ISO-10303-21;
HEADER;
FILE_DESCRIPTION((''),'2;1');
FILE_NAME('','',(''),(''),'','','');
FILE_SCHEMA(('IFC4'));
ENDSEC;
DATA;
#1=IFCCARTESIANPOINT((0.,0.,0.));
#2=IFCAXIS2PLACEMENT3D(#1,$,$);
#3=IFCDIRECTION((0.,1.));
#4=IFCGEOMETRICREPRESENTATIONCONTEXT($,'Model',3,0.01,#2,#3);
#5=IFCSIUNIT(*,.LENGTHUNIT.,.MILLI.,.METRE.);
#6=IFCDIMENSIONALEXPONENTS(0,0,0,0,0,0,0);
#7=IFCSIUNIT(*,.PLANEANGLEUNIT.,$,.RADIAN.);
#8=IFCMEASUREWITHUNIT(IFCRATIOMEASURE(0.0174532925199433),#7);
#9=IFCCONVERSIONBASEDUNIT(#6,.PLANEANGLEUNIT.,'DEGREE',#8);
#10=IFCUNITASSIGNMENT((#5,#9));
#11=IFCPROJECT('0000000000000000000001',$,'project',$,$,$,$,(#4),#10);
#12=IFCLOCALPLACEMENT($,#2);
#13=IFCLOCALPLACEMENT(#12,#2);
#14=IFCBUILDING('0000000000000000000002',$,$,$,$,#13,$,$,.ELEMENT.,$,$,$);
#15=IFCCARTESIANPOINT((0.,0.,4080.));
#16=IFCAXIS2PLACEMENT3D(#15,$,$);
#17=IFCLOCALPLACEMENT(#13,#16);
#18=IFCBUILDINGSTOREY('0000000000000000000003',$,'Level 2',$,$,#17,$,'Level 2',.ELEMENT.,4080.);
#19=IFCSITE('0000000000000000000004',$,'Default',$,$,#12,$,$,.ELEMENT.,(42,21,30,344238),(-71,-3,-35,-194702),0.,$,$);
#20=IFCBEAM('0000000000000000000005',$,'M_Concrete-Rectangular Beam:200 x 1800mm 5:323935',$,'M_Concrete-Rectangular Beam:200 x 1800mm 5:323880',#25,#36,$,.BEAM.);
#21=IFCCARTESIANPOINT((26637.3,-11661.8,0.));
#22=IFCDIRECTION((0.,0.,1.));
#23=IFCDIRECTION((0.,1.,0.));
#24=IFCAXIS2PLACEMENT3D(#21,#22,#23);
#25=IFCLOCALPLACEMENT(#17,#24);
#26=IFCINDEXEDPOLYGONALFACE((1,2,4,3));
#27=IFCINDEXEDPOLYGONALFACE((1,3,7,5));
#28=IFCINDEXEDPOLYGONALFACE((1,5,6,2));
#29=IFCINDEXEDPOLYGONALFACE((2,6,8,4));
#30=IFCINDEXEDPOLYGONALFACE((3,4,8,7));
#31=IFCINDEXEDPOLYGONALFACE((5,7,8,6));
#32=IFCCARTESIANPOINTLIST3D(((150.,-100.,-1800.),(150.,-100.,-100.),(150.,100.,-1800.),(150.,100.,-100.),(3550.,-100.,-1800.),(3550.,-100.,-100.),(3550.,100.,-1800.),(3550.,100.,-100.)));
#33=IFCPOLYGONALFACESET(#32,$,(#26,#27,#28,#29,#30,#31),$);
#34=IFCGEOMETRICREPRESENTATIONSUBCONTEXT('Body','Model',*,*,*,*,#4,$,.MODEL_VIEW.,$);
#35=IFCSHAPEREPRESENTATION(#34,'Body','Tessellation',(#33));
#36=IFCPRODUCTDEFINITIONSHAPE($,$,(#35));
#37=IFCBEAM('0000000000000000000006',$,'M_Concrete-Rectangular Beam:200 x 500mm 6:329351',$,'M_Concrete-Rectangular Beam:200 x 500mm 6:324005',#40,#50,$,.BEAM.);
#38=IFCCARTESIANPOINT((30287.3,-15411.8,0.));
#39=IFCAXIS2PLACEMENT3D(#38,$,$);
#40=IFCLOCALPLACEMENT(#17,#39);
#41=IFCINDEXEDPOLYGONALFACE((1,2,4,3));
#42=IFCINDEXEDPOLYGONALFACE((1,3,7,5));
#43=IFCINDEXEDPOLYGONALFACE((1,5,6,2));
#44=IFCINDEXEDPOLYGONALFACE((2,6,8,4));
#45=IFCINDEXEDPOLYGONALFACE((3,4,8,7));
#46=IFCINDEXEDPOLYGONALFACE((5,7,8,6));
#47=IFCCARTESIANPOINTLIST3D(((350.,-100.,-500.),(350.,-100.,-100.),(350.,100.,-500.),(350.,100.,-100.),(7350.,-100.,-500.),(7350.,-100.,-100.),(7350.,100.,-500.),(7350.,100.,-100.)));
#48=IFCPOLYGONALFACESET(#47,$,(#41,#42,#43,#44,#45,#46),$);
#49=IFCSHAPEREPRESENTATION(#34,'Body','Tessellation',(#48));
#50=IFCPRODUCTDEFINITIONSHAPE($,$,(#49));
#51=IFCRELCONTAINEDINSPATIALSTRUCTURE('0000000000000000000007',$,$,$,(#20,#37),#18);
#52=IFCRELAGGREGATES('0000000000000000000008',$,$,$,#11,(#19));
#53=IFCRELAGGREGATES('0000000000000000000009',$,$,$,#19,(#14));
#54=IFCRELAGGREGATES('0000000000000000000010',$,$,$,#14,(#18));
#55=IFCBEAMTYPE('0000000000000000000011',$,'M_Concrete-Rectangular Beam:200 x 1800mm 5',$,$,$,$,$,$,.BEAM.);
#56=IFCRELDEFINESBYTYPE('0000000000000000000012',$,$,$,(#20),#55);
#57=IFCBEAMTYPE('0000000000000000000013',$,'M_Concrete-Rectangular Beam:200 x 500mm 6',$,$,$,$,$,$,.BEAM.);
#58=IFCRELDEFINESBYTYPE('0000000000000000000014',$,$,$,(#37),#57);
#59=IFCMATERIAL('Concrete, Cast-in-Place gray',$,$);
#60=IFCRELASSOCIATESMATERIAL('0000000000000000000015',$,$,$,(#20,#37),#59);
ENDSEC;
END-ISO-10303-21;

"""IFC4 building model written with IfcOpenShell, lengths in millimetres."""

from ifc_helpers import new_model, entity, si_unit, converted_unit, direction, frame, frame_2d, origin, place, context, subcontext, project, spatial, rectangle, extrude, material, type_object, element, save


model = new_model("IFC4")

# Units and contexts
model_context = context("Model", 3, precision=0.01, world=origin(), true_north=direction((0.0, 1.0)))
body_context = subcontext(model_context, "Body", "Model", "MODEL_VIEW")
ifc_project = project(units=[si_unit("LENGTHUNIT", "METRE", prefix="MILLI"), converted_unit("PLANEANGLEUNIT", "DEGREE", entity("IfcRatioMeasure", 0.0174532925199433), si_unit("PLANEANGLEUNIT", "RADIAN"), dimensions=[0, 0, 0, 0, 0, 0, 0])], contexts=[model_context])

# Site, building, storey
site_placement = place(None, origin())
site = spatial("IfcSite", under=ifc_project, at=site_placement, Name="Default", CompositionType="ELEMENT", RefLatitude=(42, 21, 30, 344238), RefLongitude=(-71, -3, -35, -194702), RefElevation=0.0)
building_placement = place(site_placement, origin())
building = spatial("IfcBuilding", under=site, at=building_placement, CompositionType="ELEMENT")
storey_placement = place(building_placement, frame((0.0, 0.0, 4080.0)))
storey = spatial("IfcBuildingStorey", under=building, at=storey_placement, Name="Level 2", LongName="Level 2", CompositionType="ELEMENT", Elevation=4080.0)

# Beams
ifc_material_1 = material(Name="Concrete, Cast-in-Place gray")
beam_type_1 = type_object("IfcBeamType", Name="M_Concrete-Rectangular Beam:200 x 1800mm 5", PredefinedType="BEAM")
beam_1_placement = place(storey_placement, frame((26637.3, -11661.8, 0.0), z_axis=(0.0, 0.0, 1.0), x_axis=(0.0, 1.0, 0.0)))
element("IfcBeam", 1, at=beam_1_placement, inside=storey, type_object=beam_type_1, material=ifc_material_1, Name="M_Concrete-Rectangular Beam:200 x 1800mm 5:323935", ObjectType="M_Concrete-Rectangular Beam:200 x 1800mm 5:323880", PredefinedType="BEAM", context=body_context, shape_type="SweptSolid", body=[
    extrude(rectangle(XDim=1700.0, YDim=200.0, at=frame_2d((0.0, 0.0), x_axis=(1.0, 0.0))), frame((150.0, 0.0, -950.0), z_axis=(1.0, 0.0, 0.0), x_axis=(0.0, 0.0, -1.0)), (0.0, 0.0, 1.0), 3400.0),
])
beam_type_2 = type_object("IfcBeamType", Name="M_Concrete-Rectangular Beam:200 x 500mm 6", PredefinedType="BEAM")
beam_2_placement = place(storey_placement, frame((30287.3, -15411.8, 0.0)))
element("IfcBeam", 2, at=beam_2_placement, inside=storey, type_object=beam_type_2, material=ifc_material_1, Name="M_Concrete-Rectangular Beam:200 x 500mm 6:329351", ObjectType="M_Concrete-Rectangular Beam:200 x 500mm 6:324005", PredefinedType="BEAM", context=body_context, shape_type="SweptSolid", body=[
    extrude(rectangle(XDim=400.0, YDim=200.0, at=frame_2d((0.0, 0.0), x_axis=(1.0, 0.0))), frame((350.0, 0.0, -300.0), z_axis=(1.0, 0.0, 0.0), x_axis=(0.0, 0.0, -1.0)), (0.0, 0.0, 1.0), 7000.0),
])

save(model, "model.ifc")
